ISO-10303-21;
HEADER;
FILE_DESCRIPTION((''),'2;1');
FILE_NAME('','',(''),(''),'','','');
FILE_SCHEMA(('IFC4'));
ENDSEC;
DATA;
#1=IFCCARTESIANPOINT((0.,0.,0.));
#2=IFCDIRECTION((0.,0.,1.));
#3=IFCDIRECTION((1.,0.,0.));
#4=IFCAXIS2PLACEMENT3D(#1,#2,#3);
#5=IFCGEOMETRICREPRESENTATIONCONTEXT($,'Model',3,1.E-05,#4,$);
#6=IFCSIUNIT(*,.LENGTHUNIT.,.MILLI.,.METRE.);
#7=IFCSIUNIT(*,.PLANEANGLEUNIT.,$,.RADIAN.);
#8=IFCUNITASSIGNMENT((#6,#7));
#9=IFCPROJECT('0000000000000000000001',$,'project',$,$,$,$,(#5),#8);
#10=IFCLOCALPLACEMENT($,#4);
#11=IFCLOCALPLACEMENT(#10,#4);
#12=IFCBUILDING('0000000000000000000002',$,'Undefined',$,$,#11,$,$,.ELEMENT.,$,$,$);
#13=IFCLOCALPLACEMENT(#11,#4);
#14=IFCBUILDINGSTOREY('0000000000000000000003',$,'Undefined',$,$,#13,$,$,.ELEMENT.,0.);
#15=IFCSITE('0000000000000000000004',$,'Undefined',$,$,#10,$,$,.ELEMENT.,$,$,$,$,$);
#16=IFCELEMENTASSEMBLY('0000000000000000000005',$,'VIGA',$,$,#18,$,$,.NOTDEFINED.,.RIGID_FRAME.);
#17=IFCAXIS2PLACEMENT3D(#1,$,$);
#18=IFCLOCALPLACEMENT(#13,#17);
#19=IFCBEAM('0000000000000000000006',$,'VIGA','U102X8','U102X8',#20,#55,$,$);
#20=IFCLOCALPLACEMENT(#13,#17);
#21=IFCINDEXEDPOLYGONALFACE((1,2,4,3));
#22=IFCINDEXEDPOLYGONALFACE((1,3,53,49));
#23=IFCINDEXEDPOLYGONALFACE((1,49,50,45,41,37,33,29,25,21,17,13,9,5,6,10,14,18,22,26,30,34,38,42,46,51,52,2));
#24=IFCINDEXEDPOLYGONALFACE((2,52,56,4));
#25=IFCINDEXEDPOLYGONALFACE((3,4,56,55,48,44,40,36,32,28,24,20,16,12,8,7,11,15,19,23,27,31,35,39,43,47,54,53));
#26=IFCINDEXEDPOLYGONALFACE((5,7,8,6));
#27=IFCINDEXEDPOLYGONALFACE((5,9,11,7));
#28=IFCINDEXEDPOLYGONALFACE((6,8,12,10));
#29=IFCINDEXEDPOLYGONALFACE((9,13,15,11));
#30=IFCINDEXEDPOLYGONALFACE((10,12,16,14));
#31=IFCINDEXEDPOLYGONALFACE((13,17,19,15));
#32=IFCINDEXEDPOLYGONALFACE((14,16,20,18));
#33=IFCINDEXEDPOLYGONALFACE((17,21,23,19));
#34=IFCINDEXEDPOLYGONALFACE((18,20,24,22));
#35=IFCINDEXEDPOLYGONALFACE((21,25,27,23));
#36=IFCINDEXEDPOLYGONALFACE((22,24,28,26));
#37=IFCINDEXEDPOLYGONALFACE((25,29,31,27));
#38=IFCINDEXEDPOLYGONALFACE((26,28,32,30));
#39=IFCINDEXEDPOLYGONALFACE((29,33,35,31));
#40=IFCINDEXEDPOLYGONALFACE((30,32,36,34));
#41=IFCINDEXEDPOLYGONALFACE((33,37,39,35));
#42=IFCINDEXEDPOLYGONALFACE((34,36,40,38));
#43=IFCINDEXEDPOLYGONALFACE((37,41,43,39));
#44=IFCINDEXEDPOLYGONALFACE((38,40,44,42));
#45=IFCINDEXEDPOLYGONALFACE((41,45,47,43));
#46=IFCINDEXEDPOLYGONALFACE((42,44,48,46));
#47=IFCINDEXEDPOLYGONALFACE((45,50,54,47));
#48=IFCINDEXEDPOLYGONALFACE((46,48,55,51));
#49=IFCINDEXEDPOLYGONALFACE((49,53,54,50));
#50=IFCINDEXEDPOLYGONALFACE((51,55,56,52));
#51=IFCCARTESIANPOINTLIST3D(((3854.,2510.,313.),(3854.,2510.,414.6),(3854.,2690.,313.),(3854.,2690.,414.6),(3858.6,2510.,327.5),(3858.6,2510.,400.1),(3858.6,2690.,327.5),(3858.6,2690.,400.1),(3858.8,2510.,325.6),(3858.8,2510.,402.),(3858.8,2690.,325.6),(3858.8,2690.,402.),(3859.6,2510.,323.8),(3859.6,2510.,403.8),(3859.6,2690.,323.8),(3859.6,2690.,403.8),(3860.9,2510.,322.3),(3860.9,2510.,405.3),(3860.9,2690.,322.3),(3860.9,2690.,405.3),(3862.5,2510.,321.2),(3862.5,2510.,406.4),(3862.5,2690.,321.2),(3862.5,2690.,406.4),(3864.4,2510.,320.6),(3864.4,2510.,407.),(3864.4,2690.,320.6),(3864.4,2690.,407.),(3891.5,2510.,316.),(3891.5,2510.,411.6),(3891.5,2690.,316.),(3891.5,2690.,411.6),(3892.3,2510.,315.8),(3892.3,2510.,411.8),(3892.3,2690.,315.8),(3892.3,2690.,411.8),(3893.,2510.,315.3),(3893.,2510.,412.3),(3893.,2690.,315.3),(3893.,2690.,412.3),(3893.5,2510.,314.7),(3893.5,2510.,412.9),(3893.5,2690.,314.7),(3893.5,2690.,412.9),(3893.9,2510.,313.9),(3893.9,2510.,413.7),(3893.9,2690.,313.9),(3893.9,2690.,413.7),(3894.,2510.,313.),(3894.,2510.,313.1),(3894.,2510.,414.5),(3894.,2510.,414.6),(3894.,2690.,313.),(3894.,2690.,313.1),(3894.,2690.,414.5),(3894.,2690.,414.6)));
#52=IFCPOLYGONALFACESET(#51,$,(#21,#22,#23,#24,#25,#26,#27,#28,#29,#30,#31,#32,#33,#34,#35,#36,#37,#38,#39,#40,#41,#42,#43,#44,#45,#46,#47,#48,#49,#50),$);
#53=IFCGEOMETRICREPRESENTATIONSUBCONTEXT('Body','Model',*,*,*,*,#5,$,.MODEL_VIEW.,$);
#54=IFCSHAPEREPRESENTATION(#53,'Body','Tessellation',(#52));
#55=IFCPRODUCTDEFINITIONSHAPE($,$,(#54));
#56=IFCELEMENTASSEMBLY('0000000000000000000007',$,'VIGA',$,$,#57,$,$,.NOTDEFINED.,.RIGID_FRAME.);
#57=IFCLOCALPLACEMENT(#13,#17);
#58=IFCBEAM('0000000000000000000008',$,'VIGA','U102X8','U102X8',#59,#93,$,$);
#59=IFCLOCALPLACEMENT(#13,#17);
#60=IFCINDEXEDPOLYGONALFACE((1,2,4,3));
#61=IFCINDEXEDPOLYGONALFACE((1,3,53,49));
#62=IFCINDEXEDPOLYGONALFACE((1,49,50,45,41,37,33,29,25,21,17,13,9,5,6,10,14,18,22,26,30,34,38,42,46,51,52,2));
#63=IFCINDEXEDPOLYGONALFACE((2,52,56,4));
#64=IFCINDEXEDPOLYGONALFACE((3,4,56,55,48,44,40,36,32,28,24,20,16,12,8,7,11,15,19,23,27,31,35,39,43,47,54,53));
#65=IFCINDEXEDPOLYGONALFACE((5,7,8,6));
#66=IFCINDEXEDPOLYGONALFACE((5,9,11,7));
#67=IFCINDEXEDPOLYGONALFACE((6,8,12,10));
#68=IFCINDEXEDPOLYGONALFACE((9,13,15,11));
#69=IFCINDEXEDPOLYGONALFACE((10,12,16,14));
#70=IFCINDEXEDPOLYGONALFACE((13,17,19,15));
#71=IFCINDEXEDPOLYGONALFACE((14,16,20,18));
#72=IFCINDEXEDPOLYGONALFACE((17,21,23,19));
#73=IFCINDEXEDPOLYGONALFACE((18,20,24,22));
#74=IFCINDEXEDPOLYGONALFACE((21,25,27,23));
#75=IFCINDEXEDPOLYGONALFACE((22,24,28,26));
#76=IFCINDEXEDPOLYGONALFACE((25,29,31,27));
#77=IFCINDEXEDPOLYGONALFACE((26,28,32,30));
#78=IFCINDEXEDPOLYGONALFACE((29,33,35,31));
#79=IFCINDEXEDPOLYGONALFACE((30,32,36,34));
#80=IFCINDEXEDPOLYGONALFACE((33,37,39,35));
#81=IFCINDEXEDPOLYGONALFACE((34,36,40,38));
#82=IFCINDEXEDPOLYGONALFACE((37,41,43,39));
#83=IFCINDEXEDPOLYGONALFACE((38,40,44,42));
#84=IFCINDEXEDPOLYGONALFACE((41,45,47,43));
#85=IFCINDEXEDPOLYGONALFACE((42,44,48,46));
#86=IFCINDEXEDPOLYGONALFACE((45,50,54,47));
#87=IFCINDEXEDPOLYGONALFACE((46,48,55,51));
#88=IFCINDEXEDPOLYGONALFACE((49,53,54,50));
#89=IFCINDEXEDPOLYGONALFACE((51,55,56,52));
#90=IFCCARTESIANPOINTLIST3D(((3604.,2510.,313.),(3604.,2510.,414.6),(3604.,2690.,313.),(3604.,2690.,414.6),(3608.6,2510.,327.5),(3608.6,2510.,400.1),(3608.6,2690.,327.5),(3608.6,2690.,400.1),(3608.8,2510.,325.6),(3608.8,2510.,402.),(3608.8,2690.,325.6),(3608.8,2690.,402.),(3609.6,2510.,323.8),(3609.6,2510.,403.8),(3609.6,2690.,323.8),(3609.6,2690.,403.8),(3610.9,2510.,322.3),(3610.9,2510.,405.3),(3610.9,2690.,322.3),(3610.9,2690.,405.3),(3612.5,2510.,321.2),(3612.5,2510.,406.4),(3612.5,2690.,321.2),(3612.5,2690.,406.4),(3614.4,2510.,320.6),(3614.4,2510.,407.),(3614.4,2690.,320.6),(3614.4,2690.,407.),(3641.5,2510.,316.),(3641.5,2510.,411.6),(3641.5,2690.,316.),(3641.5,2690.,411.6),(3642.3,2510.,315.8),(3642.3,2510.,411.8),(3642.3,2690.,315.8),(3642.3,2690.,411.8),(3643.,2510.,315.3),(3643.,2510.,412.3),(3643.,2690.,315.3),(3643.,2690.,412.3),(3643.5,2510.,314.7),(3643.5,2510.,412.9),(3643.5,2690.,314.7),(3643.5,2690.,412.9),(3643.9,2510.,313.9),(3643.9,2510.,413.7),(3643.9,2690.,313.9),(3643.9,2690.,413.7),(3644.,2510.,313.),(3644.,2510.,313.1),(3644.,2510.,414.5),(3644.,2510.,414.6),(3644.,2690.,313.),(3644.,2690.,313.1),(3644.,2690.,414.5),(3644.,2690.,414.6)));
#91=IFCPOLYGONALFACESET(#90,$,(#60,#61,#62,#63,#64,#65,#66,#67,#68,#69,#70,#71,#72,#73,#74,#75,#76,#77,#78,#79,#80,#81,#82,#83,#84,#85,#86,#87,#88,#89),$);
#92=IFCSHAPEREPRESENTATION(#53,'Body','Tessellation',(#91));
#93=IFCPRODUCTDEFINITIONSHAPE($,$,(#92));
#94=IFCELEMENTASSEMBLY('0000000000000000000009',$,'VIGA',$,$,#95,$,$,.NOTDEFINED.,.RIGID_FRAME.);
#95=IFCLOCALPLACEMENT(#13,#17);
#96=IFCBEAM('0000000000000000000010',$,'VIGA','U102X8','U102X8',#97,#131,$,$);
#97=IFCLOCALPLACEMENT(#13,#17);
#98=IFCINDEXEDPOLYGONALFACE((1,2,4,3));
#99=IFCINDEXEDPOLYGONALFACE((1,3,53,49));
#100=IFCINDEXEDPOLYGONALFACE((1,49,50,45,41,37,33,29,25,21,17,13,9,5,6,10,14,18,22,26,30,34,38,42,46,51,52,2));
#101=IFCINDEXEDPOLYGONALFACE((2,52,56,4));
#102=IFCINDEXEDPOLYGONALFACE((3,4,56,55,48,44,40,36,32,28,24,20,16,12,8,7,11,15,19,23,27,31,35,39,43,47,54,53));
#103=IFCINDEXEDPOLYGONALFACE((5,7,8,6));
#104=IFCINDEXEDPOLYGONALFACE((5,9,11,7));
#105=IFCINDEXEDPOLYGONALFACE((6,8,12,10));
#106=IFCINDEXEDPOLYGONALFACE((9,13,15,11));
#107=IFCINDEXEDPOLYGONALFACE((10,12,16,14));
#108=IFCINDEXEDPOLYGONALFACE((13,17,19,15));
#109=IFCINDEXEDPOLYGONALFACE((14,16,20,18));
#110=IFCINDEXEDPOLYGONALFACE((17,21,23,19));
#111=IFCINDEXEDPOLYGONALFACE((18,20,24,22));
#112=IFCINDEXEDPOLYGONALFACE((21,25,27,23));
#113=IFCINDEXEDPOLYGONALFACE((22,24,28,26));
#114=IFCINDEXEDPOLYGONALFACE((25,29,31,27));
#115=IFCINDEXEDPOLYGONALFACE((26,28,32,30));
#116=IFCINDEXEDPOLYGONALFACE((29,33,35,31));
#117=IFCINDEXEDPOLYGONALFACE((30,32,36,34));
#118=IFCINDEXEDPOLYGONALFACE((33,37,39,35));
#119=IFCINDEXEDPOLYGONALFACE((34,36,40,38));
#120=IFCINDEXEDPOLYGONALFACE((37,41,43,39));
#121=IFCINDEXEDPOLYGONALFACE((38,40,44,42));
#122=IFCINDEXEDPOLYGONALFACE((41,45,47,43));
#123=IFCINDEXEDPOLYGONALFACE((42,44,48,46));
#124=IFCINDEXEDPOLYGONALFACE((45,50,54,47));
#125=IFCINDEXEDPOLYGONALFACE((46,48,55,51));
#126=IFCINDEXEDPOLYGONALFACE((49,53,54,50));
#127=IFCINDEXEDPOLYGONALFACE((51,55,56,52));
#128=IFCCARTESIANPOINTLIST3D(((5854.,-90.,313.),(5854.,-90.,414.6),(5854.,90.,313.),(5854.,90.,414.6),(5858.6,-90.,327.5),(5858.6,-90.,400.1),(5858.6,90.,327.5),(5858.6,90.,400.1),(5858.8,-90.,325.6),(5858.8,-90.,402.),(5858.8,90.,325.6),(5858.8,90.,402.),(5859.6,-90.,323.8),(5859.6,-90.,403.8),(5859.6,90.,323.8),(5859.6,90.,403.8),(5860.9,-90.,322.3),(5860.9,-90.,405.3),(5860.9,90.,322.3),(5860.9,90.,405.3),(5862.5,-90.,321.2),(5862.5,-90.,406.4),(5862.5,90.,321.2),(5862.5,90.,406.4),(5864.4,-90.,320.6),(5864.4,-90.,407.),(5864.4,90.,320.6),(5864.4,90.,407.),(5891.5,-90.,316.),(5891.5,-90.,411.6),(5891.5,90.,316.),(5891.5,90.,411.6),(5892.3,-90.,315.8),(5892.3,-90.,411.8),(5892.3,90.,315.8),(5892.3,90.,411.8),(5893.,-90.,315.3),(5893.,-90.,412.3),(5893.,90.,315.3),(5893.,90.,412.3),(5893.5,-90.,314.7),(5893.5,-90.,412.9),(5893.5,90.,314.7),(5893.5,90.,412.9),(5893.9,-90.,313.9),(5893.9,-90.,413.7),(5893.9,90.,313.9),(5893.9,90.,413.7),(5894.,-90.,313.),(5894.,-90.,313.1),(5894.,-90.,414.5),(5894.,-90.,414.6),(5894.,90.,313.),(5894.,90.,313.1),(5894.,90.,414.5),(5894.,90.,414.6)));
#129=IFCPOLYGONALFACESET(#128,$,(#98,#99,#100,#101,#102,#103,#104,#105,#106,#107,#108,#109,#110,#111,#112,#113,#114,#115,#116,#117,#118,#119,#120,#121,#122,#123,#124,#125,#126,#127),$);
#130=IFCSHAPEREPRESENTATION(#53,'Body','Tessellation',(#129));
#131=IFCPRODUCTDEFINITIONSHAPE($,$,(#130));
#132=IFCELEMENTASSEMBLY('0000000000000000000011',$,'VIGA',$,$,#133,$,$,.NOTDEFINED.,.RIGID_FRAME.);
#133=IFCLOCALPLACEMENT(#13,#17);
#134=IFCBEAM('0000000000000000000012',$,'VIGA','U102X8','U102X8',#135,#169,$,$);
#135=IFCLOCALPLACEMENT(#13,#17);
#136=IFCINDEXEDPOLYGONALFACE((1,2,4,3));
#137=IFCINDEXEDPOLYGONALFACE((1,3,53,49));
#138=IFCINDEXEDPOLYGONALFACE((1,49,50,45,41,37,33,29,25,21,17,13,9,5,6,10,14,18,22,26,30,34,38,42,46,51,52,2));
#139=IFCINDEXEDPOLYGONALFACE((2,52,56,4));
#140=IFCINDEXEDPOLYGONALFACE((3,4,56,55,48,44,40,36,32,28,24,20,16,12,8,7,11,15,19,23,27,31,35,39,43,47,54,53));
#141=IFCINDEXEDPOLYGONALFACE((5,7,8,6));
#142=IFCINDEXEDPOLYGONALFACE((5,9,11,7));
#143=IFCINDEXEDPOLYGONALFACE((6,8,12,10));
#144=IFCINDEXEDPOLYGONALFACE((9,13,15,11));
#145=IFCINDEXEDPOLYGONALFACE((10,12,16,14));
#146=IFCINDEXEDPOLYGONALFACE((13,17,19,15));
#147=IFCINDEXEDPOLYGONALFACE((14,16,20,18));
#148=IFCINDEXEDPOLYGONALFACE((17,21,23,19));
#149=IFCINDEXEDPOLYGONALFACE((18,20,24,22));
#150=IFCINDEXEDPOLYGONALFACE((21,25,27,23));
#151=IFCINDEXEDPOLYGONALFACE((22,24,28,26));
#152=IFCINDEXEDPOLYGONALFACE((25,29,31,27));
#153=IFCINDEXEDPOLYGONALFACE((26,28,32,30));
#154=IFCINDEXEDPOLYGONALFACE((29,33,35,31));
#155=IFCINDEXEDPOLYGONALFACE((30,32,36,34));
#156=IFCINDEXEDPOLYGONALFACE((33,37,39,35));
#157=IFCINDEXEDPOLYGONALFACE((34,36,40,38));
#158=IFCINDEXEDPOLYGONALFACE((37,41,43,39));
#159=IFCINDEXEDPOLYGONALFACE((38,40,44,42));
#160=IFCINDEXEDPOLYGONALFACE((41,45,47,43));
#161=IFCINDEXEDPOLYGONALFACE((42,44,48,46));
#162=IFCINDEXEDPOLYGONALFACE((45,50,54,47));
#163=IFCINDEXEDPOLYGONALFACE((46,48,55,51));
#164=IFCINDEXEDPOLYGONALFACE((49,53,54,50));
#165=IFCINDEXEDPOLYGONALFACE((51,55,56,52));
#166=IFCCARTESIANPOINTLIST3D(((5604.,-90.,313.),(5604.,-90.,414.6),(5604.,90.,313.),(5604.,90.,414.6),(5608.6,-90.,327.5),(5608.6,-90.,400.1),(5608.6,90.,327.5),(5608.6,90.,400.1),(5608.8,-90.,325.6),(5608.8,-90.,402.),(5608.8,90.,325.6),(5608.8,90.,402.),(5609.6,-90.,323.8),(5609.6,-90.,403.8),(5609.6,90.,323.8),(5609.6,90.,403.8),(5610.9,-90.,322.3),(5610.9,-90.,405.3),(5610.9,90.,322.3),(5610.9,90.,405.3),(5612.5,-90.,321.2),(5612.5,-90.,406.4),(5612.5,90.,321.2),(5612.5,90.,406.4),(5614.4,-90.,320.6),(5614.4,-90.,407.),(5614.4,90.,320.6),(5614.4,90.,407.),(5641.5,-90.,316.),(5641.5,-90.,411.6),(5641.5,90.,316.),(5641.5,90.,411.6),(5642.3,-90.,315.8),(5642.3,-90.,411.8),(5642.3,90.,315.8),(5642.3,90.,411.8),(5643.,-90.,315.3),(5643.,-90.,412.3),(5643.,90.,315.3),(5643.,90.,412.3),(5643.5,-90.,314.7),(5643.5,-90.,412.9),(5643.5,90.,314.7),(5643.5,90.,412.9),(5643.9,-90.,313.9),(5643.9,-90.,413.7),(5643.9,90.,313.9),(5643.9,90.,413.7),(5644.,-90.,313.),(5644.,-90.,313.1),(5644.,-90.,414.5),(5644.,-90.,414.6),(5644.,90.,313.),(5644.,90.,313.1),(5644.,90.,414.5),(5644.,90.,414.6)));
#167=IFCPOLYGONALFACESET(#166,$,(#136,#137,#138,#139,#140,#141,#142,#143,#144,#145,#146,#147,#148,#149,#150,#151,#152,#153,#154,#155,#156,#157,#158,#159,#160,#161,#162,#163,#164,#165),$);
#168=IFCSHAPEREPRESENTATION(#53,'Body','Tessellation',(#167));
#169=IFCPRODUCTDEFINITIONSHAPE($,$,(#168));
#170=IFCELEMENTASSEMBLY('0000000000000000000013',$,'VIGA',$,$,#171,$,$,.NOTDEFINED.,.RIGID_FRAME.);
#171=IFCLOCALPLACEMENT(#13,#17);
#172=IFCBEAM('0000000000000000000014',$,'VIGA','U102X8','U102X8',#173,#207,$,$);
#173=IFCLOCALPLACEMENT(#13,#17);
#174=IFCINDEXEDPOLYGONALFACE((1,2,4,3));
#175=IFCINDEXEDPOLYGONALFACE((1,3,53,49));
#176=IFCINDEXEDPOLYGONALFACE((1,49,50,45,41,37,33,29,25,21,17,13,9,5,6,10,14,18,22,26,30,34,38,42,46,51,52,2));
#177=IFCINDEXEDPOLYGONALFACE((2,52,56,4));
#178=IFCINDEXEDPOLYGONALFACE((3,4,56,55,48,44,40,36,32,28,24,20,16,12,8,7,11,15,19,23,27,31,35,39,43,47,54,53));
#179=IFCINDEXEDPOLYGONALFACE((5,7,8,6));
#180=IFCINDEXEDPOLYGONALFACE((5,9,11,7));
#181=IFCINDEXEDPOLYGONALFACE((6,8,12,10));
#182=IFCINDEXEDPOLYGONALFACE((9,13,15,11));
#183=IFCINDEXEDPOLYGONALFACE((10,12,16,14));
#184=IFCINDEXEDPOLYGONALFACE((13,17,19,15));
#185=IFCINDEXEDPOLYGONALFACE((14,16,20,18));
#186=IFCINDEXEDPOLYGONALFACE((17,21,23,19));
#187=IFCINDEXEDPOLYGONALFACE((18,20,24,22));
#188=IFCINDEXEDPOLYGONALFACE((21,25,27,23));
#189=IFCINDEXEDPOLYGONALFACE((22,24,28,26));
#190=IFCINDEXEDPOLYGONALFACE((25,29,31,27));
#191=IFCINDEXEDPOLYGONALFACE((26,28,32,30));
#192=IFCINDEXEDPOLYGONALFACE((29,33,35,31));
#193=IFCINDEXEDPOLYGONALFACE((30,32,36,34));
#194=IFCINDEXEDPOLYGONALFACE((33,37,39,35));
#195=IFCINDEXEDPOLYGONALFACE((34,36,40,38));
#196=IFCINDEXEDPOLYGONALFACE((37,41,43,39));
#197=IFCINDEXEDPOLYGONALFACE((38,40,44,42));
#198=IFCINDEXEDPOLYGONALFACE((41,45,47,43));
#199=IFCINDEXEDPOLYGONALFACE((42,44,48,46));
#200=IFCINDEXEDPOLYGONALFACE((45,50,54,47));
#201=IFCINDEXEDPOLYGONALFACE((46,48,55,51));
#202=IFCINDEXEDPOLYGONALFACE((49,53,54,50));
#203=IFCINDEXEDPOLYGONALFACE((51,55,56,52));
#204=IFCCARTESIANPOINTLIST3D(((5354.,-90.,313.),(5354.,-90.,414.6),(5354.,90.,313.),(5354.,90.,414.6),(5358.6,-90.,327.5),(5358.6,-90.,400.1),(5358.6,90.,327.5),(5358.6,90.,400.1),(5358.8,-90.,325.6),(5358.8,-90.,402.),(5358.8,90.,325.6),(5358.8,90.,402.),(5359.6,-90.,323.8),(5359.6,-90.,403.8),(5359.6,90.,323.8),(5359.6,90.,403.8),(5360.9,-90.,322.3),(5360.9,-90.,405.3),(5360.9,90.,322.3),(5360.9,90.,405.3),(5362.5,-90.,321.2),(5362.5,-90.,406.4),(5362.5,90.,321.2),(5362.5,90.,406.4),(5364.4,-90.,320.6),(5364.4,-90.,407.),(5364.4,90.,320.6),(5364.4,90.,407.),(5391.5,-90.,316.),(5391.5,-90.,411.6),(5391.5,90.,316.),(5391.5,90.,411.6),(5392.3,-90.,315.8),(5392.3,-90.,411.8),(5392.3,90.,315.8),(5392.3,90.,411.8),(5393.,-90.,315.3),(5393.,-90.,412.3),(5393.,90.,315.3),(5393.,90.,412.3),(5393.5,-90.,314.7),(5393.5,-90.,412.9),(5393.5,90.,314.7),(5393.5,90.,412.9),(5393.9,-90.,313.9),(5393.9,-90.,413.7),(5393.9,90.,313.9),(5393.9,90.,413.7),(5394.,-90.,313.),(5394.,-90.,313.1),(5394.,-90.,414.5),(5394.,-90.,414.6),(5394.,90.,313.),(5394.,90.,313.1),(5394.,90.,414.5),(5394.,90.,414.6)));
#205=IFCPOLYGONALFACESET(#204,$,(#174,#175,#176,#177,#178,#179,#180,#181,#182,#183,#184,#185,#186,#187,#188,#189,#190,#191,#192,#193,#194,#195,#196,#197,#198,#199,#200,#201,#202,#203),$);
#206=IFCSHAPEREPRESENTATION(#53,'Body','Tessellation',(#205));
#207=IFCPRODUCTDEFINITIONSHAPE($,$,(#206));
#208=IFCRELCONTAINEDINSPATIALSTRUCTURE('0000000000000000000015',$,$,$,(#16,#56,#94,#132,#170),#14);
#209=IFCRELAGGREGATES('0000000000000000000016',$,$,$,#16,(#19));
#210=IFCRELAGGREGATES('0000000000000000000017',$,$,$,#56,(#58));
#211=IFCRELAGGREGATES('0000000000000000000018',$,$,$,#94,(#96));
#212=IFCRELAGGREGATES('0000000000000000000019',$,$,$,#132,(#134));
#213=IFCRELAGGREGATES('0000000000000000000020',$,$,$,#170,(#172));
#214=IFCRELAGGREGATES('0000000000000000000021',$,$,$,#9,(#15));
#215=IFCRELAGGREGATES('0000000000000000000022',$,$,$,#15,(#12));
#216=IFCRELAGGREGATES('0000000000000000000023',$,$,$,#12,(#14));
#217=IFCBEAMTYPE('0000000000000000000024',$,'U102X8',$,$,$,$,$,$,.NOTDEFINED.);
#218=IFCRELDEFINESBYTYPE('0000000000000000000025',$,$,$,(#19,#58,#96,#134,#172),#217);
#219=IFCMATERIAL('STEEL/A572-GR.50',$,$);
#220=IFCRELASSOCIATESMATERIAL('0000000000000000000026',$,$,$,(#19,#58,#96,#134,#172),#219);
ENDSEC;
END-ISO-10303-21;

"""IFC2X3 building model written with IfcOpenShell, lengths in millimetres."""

from ifc_helpers import new_model, si_unit, frame, origin_with_axes, origin_2d_with_axis, place, context, subcontext, project, spatial, u_section, extrude, material, type_object, element, aggregate, save


model = new_model("IFC2X3")

# Units and contexts
model_context = context("Model", 3, precision=1e-05, world=origin_with_axes())
body_context = subcontext(model_context, "Body", "Model", "MODEL_VIEW")
ifc_project = project(units=[si_unit("LENGTHUNIT", "METRE", prefix="MILLI"), si_unit("PLANEANGLEUNIT", "RADIAN")], contexts=[model_context])

# Site, building, storey
site_placement = place(None, origin_with_axes())
site = spatial("IfcSite", under=ifc_project, at=site_placement, Name="Undefined", CompositionType="ELEMENT")
building_placement = place(site_placement, origin_with_axes())
building = spatial("IfcBuilding", under=site, at=building_placement, Name="Undefined", CompositionType="ELEMENT")
storey_placement = place(building_placement, origin_with_axes())
storey = spatial("IfcBuildingStorey", under=building, at=storey_placement, Name="Undefined", CompositionType="ELEMENT", Elevation=0.0)

# Element assemblies, beams
ifc_material_1 = material(Name="STEEL/A572-GR.50")
beam_type_1 = type_object("IfcBeamType", Name="U102X8", PredefinedType="NOTDEFINED")
assembly_1_placement = place(storey_placement, origin_with_axes())
assembly_1 = element("IfcElementAssembly", 1, at=assembly_1_placement, inside=storey, Name="VIGA", AssemblyPlace="NOTDEFINED", PredefinedType="RIGID_FRAME")
beam_1_placement = place(assembly_1_placement, frame((3874.0, 2510.0, 363.8), z_axis=(0.0, 0.0, 1.0), x_axis=(0.0, 1.0, 0.0)))
beam_1 = element("IfcBeam", 2, at=beam_1_placement, type_object=beam_type_1, material=ifc_material_1, Name="VIGA", Description="U102X8", ObjectType="U102X8", context=body_context, shape_type="SweptSolid", body=[
    extrude(u_section(Depth=101.6, FlangeWidth=40.0, WebThickness=4.6, FlangeThickness=6.0, FilletRadius=7.0, EdgeRadius=3.0, FlangeSlope=0.16839, at=origin_2d_with_axis()), frame((180.0, 0.0, 0.0), z_axis=(-1.0, 0.0, 0.0), x_axis=(0.0, -1.0, 0.0)), (0.0, 0.0, 1.0), 180.0),
])
aggregate(assembly_1, [beam_1])
assembly_2_placement = place(storey_placement, origin_with_axes())
assembly_2 = element("IfcElementAssembly", 3, at=assembly_2_placement, inside=storey, Name="VIGA", AssemblyPlace="NOTDEFINED", PredefinedType="RIGID_FRAME")
beam_2_placement = place(assembly_2_placement, frame((3624.0, 2510.0, 363.8), z_axis=(0.0, 0.0, 1.0), x_axis=(0.0, 1.0, 0.0)))
beam_2 = element("IfcBeam", 4, at=beam_2_placement, type_object=beam_type_1, material=ifc_material_1, Name="VIGA", Description="U102X8", ObjectType="U102X8", context=body_context, shape_type="SweptSolid", body=[
    extrude(u_section(Depth=101.6, FlangeWidth=40.0, WebThickness=4.6, FlangeThickness=6.0, FilletRadius=7.0, EdgeRadius=3.0, FlangeSlope=0.16839, at=origin_2d_with_axis()), frame((180.0, 0.0, 0.0), z_axis=(-1.0, 0.0, 0.0), x_axis=(0.0, -1.0, 0.0)), (0.0, 0.0, 1.0), 180.0),
])
aggregate(assembly_2, [beam_2])
assembly_3_placement = place(storey_placement, origin_with_axes())
assembly_3 = element("IfcElementAssembly", 5, at=assembly_3_placement, inside=storey, Name="VIGA", AssemblyPlace="NOTDEFINED", PredefinedType="RIGID_FRAME")
beam_3_placement = place(assembly_3_placement, frame((5874.0, -90.0, 363.8), z_axis=(0.0, 0.0, 1.0), x_axis=(0.0, 1.0, 0.0)))
beam_3 = element("IfcBeam", 6, at=beam_3_placement, type_object=beam_type_1, material=ifc_material_1, Name="VIGA", Description="U102X8", ObjectType="U102X8", context=body_context, shape_type="SweptSolid", body=[
    extrude(u_section(Depth=101.6, FlangeWidth=40.0, WebThickness=4.6, FlangeThickness=6.0, FilletRadius=7.0, EdgeRadius=3.0, FlangeSlope=0.16839, at=origin_2d_with_axis()), frame((180.0, 0.0, 0.0), z_axis=(-1.0, 0.0, 0.0), x_axis=(0.0, -1.0, 0.0)), (0.0, 0.0, 1.0), 180.0),
])
aggregate(assembly_3, [beam_3])
assembly_4_placement = place(storey_placement, origin_with_axes())
assembly_4 = element("IfcElementAssembly", 7, at=assembly_4_placement, inside=storey, Name="VIGA", AssemblyPlace="NOTDEFINED", PredefinedType="RIGID_FRAME")
beam_4_placement = place(assembly_4_placement, frame((5624.0, -90.0, 363.8), z_axis=(0.0, 0.0, 1.0), x_axis=(0.0, 1.0, 0.0)))
beam_4 = element("IfcBeam", 8, at=beam_4_placement, type_object=beam_type_1, material=ifc_material_1, Name="VIGA", Description="U102X8", ObjectType="U102X8", context=body_context, shape_type="SweptSolid", body=[
    extrude(u_section(Depth=101.6, FlangeWidth=40.0, WebThickness=4.6, FlangeThickness=6.0, FilletRadius=7.0, EdgeRadius=3.0, FlangeSlope=0.16839, at=origin_2d_with_axis()), frame((180.0, 0.0, 0.0), z_axis=(-1.0, 0.0, 0.0), x_axis=(0.0, -1.0, 0.0)), (0.0, 0.0, 1.0), 180.0),
])
aggregate(assembly_4, [beam_4])
assembly_5_placement = place(storey_placement, origin_with_axes())
assembly_5 = element("IfcElementAssembly", 9, at=assembly_5_placement, inside=storey, Name="VIGA", AssemblyPlace="NOTDEFINED", PredefinedType="RIGID_FRAME")
beam_5_placement = place(assembly_5_placement, frame((5374.0, -90.0, 363.8), z_axis=(0.0, 0.0, 1.0), x_axis=(0.0, 1.0, 0.0)))
beam_5 = element("IfcBeam", 10, at=beam_5_placement, type_object=beam_type_1, material=ifc_material_1, Name="VIGA", Description="U102X8", ObjectType="U102X8", context=body_context, shape_type="SweptSolid", body=[
    extrude(u_section(Depth=101.6, FlangeWidth=40.0, WebThickness=4.6, FlangeThickness=6.0, FilletRadius=7.0, EdgeRadius=3.0, FlangeSlope=0.16839, at=origin_2d_with_axis()), frame((180.0, 0.0, 0.0), z_axis=(-1.0, 0.0, 0.0), x_axis=(0.0, -1.0, 0.0)), (0.0, 0.0, 1.0), 180.0),
])
aggregate(assembly_5, [beam_5])

save(model, "model.ifc")
